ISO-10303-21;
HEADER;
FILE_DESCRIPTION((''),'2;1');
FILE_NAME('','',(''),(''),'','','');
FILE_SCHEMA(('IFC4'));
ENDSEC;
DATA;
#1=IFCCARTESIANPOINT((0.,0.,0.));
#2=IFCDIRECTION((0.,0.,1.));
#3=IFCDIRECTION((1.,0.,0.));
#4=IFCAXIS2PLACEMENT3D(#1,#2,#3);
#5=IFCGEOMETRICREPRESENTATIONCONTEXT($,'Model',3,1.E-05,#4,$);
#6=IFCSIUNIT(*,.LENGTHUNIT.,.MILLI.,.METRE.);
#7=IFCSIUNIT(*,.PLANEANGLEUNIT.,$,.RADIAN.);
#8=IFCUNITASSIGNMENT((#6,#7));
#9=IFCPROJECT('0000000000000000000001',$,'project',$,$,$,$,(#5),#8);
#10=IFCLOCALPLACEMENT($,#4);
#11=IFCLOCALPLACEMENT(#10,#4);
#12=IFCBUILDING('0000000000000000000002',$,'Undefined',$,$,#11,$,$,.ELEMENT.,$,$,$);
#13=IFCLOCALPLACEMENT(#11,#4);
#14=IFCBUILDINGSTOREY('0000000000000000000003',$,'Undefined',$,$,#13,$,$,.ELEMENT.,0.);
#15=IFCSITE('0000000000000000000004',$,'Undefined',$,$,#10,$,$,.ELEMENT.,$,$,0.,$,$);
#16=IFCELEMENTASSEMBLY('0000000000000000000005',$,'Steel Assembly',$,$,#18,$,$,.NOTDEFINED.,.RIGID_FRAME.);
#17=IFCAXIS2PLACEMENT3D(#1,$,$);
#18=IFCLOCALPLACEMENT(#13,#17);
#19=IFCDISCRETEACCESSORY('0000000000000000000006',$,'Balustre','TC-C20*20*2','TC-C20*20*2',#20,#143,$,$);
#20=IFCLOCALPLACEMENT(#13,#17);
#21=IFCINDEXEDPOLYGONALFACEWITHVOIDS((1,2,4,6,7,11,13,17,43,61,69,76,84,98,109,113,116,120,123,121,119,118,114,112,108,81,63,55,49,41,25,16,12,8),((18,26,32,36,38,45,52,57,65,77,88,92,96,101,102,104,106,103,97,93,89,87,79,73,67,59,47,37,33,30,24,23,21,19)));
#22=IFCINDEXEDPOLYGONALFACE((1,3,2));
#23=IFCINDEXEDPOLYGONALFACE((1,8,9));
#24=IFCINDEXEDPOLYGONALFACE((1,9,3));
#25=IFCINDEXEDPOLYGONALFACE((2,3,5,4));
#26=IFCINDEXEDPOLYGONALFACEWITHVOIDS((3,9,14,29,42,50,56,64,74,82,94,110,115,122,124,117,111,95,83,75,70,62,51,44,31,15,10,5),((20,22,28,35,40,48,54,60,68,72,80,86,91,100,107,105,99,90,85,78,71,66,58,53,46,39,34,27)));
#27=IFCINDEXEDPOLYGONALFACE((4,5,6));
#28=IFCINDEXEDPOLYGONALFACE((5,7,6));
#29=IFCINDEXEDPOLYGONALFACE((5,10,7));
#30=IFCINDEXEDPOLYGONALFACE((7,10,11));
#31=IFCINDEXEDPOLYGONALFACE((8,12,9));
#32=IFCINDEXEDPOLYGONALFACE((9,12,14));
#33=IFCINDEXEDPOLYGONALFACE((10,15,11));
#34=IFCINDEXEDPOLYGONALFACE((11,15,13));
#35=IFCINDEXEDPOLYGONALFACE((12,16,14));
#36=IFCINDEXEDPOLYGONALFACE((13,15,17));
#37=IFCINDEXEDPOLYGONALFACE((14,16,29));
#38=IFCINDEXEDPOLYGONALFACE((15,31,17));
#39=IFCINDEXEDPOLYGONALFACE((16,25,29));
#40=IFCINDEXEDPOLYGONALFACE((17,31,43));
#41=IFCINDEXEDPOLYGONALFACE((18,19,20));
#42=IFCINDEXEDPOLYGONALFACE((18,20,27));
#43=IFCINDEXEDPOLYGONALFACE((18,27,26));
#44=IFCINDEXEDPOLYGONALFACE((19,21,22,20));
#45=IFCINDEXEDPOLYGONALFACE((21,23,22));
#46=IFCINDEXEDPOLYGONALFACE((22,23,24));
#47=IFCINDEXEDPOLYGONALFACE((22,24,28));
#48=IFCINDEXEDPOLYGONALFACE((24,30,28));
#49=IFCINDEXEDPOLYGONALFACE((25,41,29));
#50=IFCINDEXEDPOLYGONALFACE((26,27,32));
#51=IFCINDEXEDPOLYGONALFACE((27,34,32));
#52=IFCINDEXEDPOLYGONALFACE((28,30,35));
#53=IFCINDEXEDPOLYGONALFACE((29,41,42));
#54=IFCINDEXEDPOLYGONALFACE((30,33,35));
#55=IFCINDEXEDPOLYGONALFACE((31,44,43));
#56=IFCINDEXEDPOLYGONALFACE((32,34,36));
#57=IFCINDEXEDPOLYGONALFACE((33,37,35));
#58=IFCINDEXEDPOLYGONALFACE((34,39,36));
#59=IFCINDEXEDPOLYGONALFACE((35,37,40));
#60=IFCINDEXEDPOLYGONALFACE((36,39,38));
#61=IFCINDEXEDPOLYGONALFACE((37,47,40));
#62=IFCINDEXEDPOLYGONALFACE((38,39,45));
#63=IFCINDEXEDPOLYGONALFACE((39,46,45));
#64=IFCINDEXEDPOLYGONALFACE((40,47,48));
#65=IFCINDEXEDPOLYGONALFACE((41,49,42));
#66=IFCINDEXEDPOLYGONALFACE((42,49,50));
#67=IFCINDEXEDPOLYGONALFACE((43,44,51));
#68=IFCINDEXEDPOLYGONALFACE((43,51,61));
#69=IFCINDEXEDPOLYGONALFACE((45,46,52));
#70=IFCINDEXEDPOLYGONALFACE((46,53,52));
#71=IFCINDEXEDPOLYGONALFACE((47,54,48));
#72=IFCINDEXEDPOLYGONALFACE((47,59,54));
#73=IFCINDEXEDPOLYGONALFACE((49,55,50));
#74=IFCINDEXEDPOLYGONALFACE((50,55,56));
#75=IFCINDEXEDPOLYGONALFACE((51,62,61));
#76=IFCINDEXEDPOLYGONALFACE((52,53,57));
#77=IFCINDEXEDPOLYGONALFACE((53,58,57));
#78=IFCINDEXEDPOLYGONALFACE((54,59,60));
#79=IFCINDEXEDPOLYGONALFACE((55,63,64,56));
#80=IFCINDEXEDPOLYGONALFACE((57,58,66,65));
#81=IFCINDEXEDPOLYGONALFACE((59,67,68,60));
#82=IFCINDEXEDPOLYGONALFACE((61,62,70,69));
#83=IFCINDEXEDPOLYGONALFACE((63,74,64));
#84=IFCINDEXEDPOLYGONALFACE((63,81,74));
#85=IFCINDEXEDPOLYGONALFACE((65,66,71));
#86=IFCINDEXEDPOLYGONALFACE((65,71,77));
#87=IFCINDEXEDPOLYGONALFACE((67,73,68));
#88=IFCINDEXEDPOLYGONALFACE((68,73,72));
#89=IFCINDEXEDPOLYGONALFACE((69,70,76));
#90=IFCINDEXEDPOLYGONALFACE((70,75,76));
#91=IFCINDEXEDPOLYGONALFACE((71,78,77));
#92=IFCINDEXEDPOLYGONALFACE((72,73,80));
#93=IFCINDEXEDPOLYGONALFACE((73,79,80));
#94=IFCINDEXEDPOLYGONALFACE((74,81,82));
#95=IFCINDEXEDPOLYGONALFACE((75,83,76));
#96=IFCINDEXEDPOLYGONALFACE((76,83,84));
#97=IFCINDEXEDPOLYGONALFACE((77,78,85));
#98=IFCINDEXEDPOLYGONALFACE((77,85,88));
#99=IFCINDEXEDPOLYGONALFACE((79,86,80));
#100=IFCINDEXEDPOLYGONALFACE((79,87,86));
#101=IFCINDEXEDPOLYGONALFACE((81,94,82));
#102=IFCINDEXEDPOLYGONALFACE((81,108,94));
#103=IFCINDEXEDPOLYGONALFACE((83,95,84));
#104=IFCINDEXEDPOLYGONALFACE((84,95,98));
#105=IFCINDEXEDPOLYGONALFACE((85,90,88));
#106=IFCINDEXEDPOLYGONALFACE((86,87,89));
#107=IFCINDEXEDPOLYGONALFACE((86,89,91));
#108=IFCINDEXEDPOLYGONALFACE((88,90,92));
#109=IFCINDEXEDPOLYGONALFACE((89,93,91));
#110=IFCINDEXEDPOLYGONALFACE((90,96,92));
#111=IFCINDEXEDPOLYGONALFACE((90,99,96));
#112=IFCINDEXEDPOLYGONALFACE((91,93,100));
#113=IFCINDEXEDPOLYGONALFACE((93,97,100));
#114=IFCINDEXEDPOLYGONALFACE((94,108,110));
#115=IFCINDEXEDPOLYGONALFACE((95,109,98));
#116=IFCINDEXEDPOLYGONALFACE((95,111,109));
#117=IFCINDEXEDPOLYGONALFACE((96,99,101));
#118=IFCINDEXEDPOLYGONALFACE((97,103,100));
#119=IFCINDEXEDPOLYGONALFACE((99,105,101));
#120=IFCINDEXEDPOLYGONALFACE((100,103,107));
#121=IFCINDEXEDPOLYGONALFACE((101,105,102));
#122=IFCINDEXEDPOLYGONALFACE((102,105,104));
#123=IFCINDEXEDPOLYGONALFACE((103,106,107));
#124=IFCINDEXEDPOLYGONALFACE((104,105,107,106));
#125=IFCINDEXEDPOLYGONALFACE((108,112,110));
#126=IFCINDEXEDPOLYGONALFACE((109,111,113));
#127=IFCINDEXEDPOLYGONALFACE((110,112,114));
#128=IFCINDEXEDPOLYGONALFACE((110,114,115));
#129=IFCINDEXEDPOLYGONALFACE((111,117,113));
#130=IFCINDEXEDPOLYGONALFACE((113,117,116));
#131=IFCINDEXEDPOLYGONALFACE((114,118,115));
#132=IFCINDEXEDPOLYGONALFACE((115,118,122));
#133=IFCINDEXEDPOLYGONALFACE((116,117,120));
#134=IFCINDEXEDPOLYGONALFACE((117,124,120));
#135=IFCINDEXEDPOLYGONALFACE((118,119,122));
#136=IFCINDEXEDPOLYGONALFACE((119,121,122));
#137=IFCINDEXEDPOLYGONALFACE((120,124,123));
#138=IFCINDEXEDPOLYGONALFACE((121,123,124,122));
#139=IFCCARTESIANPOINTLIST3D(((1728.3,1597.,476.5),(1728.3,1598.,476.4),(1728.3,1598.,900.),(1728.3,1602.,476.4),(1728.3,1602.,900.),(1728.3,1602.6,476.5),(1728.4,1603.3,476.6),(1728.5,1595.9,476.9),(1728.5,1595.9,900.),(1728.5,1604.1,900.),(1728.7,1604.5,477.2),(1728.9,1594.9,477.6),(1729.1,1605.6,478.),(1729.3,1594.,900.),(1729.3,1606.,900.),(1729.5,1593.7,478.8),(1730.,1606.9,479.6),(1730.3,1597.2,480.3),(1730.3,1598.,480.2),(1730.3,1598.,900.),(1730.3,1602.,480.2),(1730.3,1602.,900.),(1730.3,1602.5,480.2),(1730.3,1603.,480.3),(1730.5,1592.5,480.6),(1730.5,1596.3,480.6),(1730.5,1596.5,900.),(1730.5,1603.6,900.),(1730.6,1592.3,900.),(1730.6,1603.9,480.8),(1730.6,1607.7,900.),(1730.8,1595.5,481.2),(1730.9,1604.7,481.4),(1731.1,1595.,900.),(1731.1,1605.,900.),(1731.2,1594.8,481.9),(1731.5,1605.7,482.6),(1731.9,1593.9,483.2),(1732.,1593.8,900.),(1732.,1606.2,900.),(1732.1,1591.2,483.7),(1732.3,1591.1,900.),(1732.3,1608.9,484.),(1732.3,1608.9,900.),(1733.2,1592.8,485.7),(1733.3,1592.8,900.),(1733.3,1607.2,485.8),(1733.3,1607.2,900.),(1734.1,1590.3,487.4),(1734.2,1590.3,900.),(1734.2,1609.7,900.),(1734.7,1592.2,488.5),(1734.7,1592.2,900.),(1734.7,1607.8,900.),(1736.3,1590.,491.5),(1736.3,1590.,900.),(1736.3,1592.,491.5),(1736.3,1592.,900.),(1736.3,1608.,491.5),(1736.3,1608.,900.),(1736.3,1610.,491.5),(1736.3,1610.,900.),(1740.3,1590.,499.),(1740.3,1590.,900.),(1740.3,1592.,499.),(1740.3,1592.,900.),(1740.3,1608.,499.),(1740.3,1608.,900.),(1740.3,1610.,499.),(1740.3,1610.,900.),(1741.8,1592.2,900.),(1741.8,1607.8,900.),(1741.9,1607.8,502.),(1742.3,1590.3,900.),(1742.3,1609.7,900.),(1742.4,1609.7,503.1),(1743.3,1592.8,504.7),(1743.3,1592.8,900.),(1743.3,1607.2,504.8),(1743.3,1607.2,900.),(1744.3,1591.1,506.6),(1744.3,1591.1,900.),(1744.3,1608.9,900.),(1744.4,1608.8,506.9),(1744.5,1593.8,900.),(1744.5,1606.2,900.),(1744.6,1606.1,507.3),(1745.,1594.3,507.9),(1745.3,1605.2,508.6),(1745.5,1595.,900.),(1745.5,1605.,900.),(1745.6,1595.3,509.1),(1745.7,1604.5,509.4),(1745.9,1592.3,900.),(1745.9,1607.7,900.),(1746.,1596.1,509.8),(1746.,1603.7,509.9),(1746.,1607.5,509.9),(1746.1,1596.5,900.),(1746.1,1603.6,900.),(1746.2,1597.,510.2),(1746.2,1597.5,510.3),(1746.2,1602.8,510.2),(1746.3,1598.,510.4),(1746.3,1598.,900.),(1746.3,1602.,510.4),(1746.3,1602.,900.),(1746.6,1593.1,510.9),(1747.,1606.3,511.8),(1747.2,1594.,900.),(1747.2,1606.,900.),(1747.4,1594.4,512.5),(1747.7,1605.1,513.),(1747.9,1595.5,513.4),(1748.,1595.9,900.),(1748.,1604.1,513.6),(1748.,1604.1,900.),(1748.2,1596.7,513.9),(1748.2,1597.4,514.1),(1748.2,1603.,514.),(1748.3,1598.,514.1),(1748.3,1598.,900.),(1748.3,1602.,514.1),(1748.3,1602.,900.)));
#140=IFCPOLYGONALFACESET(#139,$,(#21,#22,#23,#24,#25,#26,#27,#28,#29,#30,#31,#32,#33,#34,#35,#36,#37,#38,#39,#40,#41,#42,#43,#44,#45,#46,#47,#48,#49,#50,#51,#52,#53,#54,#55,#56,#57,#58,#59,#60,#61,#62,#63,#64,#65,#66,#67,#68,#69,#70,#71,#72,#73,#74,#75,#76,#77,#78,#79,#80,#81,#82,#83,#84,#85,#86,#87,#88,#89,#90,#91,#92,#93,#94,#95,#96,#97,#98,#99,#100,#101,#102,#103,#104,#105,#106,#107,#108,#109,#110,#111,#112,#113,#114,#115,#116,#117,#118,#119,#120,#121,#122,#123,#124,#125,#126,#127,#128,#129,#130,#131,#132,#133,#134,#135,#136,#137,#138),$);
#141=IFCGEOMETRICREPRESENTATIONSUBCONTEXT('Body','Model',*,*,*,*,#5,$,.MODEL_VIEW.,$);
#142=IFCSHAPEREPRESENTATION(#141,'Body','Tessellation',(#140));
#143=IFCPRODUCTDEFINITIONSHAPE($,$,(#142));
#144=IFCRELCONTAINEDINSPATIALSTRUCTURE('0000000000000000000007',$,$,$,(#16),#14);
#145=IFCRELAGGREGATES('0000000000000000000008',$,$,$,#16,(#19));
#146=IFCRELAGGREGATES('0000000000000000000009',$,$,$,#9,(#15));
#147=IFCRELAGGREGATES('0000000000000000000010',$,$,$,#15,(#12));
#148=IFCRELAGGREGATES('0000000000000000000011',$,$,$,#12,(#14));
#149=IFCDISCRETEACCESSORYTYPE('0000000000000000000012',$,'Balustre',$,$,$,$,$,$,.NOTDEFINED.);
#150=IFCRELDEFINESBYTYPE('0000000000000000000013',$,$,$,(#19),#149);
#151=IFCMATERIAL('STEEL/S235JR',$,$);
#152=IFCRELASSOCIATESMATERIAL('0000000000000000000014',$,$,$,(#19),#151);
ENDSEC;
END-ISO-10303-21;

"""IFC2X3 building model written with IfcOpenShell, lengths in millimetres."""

from ifc_helpers import new_model, si_unit, frame, origin_with_axes, origin_2d_with_axis, place, context, subcontext, project, spatial, hollow_rectangle, extrude, clip, halfspace, material, type_object, element, aggregate, save


model = new_model("IFC2X3")

# Units and contexts
model_context = context("Model", 3, precision=1e-05, world=origin_with_axes())
body_context = subcontext(model_context, "Body", "Model", "MODEL_VIEW")
ifc_project = project(units=[si_unit("LENGTHUNIT", "METRE", prefix="MILLI"), si_unit("PLANEANGLEUNIT", "RADIAN")], contexts=[model_context])

# Site, building, storey
site_placement = place(None, origin_with_axes())
site = spatial("IfcSite", under=ifc_project, at=site_placement, Name="Undefined", CompositionType="ELEMENT", RefElevation=0.0)
building_placement = place(site_placement, origin_with_axes())
building = spatial("IfcBuilding", under=site, at=building_placement, Name="Undefined", CompositionType="ELEMENT")
storey_placement = place(building_placement, origin_with_axes())
storey = spatial("IfcBuildingStorey", under=building, at=storey_placement, Name="Undefined", CompositionType="ELEMENT", Elevation=0.0)

# Element assembly
ifc_material = material(Name="STEEL/S235JR")
assembly_1_placement = place(storey_placement, origin_with_axes())
assembly_1 = element("IfcElementAssembly", 1, at=assembly_1_placement, inside=storey, Name="Steel Assembly", AssemblyPlace="NOTDEFINED", PredefinedType="RIGID_FRAME")

# Discrete accessory
discrete_accessory_type_1 = type_object("IfcDiscreteAccessoryType", Name="Balustre")
discrete_accessory_1_placement = place(assembly_1_placement, frame((1738.3, 1600.0, 900.0), z_axis=(-0.000011, 1.0, 0.0), x_axis=(0.0, 0.0, -1.0)))
discrete_accessory_1 = element("IfcDiscreteAccessory", 2, at=discrete_accessory_1_placement, type_object=discrete_accessory_type_1, material=ifc_material, Name="Balustre", Description="TC-C20*20*2", ObjectType="TC-C20*20*2", context=body_context, shape_type="Clipping", body=[
    clip(extrude(hollow_rectangle(XDim=20.0, YDim=20.0, WallThickness=2.0, InnerFilletRadius=6.0, OuterFilletRadius=8.0, at=origin_2d_with_axis()), frame((423.8, 0.0, 0.0), z_axis=(-1.0, 0.0, 0.0), x_axis=(0.0, -1.0, 0.0)), (0.0, 0.0, 1.0), 423.8), halfspace(frame((429.9, 13.3, 0.0), z_axis=(-0.46842, 0.883506, 0.000005), x_axis=(0.0, -0.000005, 1.0)), True)),
])
aggregate(assembly_1, [discrete_accessory_1])

save(model, "model.ifc")
